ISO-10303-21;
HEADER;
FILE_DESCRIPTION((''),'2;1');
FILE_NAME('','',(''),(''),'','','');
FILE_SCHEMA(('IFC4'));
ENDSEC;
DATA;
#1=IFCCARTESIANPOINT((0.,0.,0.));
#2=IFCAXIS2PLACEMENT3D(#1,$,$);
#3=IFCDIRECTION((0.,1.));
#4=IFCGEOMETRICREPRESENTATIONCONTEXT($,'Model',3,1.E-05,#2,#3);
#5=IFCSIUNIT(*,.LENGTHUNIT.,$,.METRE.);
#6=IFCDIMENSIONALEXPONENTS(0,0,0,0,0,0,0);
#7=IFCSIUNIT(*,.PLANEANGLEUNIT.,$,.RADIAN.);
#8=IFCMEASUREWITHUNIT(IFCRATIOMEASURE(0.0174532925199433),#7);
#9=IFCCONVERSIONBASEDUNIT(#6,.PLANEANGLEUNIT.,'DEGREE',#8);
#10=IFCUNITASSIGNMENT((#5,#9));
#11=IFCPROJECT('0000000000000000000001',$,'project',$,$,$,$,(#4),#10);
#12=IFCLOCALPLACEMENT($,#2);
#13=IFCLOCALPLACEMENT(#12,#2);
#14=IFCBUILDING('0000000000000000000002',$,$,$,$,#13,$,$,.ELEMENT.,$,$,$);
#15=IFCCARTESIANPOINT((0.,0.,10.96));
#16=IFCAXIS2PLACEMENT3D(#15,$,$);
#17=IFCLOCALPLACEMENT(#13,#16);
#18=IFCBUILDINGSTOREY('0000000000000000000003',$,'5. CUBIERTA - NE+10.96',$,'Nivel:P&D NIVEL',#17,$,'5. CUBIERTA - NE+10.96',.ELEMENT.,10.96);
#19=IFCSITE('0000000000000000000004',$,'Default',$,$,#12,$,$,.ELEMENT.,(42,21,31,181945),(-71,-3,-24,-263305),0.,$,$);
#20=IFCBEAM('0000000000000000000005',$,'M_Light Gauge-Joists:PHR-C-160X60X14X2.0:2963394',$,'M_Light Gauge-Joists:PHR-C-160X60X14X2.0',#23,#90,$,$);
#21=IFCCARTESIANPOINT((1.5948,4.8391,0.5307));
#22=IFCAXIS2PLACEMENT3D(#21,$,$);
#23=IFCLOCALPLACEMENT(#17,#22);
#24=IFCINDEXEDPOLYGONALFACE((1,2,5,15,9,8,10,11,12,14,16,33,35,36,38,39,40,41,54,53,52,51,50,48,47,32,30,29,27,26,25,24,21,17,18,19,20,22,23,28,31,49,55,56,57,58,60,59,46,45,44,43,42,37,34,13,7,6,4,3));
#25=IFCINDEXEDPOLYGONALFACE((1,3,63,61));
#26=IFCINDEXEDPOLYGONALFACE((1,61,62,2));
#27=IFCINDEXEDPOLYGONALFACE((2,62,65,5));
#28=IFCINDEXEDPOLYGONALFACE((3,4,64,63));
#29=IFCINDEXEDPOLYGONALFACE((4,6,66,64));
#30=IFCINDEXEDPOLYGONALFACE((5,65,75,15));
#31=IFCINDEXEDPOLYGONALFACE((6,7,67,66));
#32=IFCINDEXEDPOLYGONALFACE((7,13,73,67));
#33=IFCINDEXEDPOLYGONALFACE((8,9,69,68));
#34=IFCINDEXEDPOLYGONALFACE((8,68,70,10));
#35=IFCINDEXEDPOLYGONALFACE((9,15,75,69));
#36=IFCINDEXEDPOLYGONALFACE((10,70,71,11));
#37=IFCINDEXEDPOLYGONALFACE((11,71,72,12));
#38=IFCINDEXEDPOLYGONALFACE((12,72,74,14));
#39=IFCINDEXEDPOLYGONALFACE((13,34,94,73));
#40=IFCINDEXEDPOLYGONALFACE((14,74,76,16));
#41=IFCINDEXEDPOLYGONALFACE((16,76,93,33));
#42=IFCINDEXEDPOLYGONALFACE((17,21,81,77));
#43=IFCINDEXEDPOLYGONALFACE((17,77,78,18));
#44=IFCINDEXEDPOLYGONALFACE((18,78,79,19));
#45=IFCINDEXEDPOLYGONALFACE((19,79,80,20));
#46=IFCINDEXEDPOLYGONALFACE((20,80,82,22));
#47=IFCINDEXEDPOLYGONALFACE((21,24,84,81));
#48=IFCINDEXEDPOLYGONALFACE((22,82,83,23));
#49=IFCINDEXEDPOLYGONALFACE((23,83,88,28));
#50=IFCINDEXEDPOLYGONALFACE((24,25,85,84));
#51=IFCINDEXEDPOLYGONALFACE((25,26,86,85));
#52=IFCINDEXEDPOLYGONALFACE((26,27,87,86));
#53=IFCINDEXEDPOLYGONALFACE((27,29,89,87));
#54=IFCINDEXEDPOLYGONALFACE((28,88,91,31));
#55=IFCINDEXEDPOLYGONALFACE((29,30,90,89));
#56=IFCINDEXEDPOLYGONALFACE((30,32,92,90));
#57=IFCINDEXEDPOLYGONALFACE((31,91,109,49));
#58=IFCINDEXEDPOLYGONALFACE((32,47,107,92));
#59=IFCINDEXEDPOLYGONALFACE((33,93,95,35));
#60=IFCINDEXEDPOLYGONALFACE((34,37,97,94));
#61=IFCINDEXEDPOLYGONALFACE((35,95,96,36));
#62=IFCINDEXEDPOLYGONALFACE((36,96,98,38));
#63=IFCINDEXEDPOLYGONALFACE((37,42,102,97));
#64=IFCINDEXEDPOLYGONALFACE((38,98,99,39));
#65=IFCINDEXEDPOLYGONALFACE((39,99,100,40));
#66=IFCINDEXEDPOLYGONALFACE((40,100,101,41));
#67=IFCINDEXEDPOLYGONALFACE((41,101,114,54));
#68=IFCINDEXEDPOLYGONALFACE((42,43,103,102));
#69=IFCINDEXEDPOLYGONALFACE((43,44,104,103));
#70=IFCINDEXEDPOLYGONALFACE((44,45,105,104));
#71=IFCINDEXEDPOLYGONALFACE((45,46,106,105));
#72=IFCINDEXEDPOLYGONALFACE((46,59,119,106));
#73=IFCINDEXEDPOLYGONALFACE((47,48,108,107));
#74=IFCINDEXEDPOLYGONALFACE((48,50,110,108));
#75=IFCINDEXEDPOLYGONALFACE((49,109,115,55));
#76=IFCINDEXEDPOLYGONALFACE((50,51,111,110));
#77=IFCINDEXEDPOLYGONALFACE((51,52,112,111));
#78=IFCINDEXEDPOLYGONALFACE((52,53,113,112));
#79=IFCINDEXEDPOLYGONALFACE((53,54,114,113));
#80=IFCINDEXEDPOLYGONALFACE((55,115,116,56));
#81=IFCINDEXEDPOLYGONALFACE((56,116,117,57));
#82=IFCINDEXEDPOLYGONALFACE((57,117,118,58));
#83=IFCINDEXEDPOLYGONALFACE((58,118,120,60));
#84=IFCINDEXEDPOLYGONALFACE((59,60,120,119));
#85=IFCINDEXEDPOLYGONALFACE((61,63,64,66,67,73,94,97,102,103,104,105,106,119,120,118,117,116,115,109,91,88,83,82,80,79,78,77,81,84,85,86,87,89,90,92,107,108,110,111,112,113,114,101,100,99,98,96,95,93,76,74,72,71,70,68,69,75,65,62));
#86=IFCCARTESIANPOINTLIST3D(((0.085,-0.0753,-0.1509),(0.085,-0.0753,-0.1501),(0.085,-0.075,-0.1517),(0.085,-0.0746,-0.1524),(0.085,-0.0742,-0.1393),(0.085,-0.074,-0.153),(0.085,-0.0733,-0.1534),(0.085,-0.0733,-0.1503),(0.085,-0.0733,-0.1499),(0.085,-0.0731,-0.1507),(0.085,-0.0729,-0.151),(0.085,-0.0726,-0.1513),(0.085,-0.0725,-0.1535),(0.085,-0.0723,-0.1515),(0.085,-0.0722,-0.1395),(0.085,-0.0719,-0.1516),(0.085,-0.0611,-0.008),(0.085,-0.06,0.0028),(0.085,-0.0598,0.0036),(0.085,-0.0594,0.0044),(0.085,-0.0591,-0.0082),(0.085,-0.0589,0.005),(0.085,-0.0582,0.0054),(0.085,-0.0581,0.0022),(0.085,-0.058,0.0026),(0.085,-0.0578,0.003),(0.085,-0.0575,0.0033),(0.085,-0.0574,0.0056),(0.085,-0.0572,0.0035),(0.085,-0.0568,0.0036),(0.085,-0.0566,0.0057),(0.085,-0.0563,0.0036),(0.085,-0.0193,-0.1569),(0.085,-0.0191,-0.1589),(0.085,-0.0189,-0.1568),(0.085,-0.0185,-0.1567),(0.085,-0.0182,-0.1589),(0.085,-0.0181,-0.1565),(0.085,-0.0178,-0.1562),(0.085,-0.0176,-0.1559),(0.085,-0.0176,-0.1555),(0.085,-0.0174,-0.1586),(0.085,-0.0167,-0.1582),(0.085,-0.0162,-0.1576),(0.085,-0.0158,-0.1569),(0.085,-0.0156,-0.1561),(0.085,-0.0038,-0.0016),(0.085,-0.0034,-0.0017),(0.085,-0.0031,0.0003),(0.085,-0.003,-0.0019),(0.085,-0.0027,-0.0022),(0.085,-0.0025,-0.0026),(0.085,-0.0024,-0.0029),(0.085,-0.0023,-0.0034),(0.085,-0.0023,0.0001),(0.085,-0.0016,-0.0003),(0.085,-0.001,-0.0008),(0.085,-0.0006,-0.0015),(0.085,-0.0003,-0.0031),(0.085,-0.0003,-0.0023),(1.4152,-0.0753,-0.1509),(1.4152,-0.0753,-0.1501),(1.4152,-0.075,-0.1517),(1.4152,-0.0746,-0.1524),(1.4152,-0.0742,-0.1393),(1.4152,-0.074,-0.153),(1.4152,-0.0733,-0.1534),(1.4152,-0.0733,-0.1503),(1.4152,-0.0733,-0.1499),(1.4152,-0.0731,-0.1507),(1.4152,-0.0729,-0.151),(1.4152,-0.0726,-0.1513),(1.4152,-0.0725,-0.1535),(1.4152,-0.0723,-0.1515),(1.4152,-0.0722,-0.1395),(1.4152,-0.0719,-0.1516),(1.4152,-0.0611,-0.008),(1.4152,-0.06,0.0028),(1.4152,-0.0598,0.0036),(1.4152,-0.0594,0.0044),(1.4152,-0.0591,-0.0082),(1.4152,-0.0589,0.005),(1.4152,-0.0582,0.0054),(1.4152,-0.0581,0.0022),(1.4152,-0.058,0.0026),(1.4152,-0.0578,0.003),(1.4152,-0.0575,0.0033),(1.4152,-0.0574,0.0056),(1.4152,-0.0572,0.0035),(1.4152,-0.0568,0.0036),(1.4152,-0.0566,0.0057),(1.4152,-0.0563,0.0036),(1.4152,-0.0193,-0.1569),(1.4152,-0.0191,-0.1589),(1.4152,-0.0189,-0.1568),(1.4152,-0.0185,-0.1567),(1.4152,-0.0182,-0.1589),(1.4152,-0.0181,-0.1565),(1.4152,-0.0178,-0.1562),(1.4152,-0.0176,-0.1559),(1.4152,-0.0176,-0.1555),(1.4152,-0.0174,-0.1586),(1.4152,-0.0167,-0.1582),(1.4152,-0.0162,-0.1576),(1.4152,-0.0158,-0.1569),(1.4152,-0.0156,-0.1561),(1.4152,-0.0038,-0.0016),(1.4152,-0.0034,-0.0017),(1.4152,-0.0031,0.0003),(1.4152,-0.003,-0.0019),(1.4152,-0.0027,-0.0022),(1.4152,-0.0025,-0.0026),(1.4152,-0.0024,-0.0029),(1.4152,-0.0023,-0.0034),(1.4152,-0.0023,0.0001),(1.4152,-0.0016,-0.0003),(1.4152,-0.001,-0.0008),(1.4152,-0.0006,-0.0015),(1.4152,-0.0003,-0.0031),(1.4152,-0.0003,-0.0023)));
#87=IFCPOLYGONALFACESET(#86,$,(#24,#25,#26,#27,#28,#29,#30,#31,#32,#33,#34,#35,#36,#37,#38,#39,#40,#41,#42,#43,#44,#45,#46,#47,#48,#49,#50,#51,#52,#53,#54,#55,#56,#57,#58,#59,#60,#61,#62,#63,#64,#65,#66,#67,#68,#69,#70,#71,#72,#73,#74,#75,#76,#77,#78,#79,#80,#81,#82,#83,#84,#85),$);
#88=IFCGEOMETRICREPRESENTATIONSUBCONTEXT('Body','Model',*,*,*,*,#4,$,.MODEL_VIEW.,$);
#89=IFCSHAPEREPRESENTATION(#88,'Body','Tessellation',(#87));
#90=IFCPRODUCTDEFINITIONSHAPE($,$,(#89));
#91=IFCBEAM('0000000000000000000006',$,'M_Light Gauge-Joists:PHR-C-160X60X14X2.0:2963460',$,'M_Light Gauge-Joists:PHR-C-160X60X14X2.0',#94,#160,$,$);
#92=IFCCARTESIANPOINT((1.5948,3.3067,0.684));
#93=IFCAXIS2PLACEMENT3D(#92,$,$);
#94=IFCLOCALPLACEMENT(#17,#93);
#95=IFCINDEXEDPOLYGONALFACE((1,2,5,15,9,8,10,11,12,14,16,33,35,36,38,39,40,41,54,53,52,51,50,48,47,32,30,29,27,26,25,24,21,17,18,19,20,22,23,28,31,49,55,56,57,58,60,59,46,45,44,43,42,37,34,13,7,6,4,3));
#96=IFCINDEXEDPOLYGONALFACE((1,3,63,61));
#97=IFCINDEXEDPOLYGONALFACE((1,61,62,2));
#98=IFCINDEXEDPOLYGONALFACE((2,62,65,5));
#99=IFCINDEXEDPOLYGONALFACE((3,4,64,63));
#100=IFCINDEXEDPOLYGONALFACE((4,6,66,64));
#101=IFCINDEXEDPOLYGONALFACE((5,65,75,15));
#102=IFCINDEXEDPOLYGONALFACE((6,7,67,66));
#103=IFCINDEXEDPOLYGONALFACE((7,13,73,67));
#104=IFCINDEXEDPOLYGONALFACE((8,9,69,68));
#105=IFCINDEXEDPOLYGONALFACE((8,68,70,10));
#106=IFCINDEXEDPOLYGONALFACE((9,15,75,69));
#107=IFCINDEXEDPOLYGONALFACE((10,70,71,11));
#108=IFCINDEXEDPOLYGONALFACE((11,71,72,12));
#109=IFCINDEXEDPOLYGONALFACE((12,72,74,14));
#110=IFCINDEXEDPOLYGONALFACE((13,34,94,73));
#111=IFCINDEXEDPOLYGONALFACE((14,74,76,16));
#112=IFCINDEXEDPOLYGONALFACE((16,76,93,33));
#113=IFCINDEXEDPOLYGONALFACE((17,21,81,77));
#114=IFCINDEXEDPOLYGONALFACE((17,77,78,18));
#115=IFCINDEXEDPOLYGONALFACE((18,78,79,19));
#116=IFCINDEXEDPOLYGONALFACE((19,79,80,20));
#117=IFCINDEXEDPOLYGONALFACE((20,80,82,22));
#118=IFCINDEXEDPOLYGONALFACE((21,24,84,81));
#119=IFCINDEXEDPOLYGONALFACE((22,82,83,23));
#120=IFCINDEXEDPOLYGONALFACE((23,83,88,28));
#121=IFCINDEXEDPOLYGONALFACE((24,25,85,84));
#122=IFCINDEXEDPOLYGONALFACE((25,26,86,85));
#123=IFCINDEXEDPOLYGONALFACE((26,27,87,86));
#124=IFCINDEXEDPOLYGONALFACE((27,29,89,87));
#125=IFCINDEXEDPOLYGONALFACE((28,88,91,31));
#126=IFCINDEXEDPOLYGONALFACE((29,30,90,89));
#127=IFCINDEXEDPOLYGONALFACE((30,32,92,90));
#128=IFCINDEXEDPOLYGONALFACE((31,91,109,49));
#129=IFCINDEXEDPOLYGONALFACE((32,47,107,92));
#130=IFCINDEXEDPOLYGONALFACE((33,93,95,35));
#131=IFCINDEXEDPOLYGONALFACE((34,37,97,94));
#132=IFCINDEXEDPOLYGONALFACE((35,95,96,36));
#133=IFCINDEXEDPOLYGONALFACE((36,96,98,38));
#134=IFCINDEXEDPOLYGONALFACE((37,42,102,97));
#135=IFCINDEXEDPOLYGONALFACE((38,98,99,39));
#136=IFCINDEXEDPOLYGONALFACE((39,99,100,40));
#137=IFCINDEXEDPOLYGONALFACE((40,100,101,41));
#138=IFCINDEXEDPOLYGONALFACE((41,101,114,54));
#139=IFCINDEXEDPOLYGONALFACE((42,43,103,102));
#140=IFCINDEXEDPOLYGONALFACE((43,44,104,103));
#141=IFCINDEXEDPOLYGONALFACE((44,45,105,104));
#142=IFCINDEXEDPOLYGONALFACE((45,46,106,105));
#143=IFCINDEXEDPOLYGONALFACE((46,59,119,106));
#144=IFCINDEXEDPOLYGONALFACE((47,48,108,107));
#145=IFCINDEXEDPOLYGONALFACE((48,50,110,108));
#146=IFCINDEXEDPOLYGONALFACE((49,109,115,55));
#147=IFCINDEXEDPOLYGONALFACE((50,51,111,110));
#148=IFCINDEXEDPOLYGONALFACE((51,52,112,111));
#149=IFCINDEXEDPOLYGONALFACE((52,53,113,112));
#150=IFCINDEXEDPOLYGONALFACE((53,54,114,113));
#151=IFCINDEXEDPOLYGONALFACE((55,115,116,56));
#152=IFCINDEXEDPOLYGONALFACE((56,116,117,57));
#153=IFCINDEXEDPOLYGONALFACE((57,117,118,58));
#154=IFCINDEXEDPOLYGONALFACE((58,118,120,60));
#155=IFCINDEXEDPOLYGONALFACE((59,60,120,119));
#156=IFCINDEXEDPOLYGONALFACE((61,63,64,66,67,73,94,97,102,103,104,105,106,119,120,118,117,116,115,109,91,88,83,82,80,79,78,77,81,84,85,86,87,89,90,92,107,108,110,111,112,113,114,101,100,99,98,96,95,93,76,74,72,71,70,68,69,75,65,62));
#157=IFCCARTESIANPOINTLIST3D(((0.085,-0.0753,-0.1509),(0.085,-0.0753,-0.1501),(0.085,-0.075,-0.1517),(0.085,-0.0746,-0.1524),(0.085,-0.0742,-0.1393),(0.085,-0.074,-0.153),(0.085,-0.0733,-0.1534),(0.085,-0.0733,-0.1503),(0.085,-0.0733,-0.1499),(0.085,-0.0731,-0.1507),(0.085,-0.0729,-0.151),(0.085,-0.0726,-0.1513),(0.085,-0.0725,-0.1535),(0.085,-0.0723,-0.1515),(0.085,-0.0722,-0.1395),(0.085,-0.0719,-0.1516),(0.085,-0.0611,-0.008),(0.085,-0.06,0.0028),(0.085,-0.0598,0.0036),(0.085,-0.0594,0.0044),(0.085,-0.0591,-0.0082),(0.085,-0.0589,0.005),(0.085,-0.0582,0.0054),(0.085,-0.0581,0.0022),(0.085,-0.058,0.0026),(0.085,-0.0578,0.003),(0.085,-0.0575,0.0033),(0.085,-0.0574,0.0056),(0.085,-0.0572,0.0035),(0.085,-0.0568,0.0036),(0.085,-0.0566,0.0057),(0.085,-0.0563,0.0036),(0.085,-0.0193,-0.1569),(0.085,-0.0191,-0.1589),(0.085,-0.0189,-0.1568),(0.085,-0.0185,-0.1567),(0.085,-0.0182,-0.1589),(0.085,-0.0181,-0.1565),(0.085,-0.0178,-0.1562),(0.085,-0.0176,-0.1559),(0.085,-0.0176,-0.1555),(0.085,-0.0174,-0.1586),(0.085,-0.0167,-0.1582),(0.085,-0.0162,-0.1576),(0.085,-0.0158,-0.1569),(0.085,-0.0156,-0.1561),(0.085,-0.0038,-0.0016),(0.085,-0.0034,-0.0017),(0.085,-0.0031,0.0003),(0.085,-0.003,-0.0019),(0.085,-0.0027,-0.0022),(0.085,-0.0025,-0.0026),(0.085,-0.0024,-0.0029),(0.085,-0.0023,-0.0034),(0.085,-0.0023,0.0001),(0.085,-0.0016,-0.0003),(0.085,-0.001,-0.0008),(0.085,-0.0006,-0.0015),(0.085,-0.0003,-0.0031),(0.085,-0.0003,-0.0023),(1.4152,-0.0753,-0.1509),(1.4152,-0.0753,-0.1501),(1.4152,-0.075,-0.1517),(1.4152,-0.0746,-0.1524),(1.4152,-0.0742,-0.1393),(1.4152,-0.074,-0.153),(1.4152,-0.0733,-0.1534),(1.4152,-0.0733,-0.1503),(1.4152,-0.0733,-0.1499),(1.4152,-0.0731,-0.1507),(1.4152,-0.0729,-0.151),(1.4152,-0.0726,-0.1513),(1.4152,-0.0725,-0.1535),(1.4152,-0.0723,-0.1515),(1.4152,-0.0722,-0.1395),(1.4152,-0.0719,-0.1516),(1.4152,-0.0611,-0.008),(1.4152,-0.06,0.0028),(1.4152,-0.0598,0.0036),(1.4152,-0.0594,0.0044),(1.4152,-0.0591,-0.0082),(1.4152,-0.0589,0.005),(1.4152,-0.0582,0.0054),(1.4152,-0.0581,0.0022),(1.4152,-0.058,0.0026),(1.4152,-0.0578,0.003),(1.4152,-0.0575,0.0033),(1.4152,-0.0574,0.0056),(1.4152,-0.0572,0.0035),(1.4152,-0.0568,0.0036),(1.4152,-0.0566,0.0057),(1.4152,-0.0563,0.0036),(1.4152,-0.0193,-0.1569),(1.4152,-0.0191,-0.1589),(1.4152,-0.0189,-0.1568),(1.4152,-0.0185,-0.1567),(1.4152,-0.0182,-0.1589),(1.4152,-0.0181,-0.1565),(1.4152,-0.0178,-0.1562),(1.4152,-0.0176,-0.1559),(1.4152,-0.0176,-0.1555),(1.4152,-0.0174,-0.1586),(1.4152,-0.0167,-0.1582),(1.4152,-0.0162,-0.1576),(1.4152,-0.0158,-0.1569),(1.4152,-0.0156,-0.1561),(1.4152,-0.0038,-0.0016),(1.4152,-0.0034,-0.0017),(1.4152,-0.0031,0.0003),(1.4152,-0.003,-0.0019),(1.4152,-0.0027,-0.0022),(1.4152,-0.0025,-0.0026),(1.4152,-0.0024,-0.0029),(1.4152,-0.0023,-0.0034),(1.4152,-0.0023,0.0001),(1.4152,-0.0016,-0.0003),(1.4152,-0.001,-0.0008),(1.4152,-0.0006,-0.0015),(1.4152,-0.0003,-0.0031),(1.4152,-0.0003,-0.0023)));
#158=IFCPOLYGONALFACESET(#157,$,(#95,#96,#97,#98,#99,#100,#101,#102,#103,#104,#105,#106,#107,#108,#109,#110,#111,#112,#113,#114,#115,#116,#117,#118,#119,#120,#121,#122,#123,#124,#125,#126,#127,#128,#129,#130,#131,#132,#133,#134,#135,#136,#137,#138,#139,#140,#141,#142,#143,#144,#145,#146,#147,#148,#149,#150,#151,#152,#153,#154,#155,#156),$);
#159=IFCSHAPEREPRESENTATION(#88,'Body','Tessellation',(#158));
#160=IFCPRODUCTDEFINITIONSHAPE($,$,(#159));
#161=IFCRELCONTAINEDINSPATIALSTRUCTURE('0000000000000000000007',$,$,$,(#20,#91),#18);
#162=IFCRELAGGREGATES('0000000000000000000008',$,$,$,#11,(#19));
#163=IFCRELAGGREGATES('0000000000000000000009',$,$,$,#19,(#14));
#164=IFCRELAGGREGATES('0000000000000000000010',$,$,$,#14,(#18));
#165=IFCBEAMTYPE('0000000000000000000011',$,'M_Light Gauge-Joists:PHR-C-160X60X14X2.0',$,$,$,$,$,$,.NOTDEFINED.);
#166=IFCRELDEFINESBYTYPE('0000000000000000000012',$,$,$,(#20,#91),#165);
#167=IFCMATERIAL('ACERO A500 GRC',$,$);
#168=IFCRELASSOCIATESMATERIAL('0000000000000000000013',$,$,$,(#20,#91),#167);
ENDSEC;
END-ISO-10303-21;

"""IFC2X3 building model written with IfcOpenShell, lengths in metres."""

from ifc_helpers import new_model, entity, si_unit, converted_unit, direction, frame, frame_2d, origin, place, context, subcontext, project, spatial, polyline, circle_curve, parameter, trimmed, segment, composite_curve, outline, extrude, material, type_object, element, save


model = new_model("IFC2X3")

# Units and contexts
model_context = context("Model", 3, precision=1e-05, world=origin(), true_north=direction((0.0, 1.0)))
body_context = subcontext(model_context, "Body", "Model", "MODEL_VIEW")
ifc_project = project(units=[si_unit("LENGTHUNIT", "METRE"), converted_unit("PLANEANGLEUNIT", "DEGREE", entity("IfcRatioMeasure", 0.0174532925199433), si_unit("PLANEANGLEUNIT", "RADIAN"), dimensions=[0, 0, 0, 0, 0, 0, 0])], contexts=[model_context])

# Site, building, storey
site_placement = place(None, origin())
site = spatial("IfcSite", under=ifc_project, at=site_placement, Name="Default", CompositionType="ELEMENT", RefLatitude=(42, 21, 31, 181945), RefLongitude=(-71, -3, -24, -263305), RefElevation=0.0)
building_placement = place(site_placement, origin())
building = spatial("IfcBuilding", under=site, at=building_placement, CompositionType="ELEMENT")
storey_placement = place(building_placement, frame((0.0, 0.0, 10.96)))
storey = spatial("IfcBuildingStorey", under=building, at=storey_placement, Name="5. CUBIERTA - NE+10.96", ObjectType="Nivel:P&D NIVEL", LongName="5. CUBIERTA - NE+10.96", CompositionType="ELEMENT", Elevation=10.96)

# Beams
ifc_material_1 = material(Name="ACERO A500 GRC")
beam_type_1 = type_object("IfcBeamType", Name="M_Light Gauge-Joists:PHR-C-160X60X14X2.0", PredefinedType="NOTDEFINED")
beam_1_placement = place(storey_placement, frame((1.5948, 4.8391, 0.5307)))
element("IfcBeam", 1, at=beam_1_placement, inside=storey, type_object=beam_type_1, material=ifc_material_1, Name="M_Light Gauge-Joists:PHR-C-160X60X14X2.0:2963394", ObjectType="M_Light Gauge-Joists:PHR-C-160X60X14X2.0", context=body_context, shape_type="SweptSolid", body=[
    extrude(outline(composite_curve([segment(polyline([(-0.0768, -0.0358), (0.0768, -0.0358)]), True, "CONTINUOUS"), segment(trimmed(circle_curve(frame_2d((0.0768, -0.0326), x_axis=(0.0, -1.0)), 0.0032), [parameter(0.0)], [parameter(90.0)], True, "PARAMETER"), True, "CONTINUOUS"), segment(polyline([(0.08, -0.0326), (0.08, 0.021)]), True, "CONTINUOUS"), segment(trimmed(circle_curve(frame_2d((0.0768, 0.021), x_axis=(1.0, 0.0)), 0.0032), [parameter(0.0)], [parameter(90.0)], True, "PARAMETER"), True, "CONTINUOUS"), segment(polyline([(0.0768, 0.0242), (0.066, 0.0242)]), True, "CONTINUOUS"), segment(polyline([(0.066, 0.0242), (0.066, 0.0222)]), True, "CONTINUOUS"), segment(polyline([(0.066, 0.0222), (0.0764, 0.0222)]), True, "CONTINUOUS"), segment(trimmed(circle_curve(frame_2d((0.0764, 0.0206), x_axis=(0.0, 1.0)), 0.0016), [parameter(270.0)], [parameter(0.0)], True, "PARAMETER"), False, "CONTINUOUS"), segment(polyline([(0.078, 0.0206), (0.078, -0.0322)]), True, "CONTINUOUS"), segment(trimmed(circle_curve(frame_2d((0.0764, -0.0322), x_axis=(1.0, 0.0)), 0.0016), [parameter(270.0)], [parameter(0.0)], True, "PARAMETER"), False, "CONTINUOUS"), segment(polyline([(0.0764, -0.0338), (-0.0764, -0.0338)]), True, "CONTINUOUS"), segment(trimmed(circle_curve(frame_2d((-0.0764, -0.0322), x_axis=(0.0, -1.0)), 0.0016), [parameter(270.0)], [parameter(0.0)], True, "PARAMETER"), False, "CONTINUOUS"), segment(polyline([(-0.078, -0.0322), (-0.078, 0.0206)]), True, "CONTINUOUS"), segment(trimmed(circle_curve(frame_2d((-0.0764, 0.0206), x_axis=(-1.0, 0.0)), 0.0016), [parameter(270.0)], [parameter(0.0)], True, "PARAMETER"), False, "CONTINUOUS"), segment(polyline([(-0.0764, 0.0222), (-0.066, 0.0222)]), True, "CONTINUOUS"), segment(polyline([(-0.066, 0.0222), (-0.066, 0.0242)]), True, "CONTINUOUS"), segment(polyline([(-0.066, 0.0242), (-0.0768, 0.0242)]), True, "CONTINUOUS"), segment(trimmed(circle_curve(frame_2d((-0.0768, 0.021), x_axis=(0.0, 1.0)), 0.0032), [parameter(0.0)], [parameter(90.0)], True, "PARAMETER"), True, "CONTINUOUS"), segment(polyline([(-0.08, 0.021), (-0.08, -0.0326)]), True, "CONTINUOUS"), segment(trimmed(circle_curve(frame_2d((-0.0768, -0.0326), x_axis=(-1.0, 0.0)), 0.0032), [parameter(0.0)], [parameter(90.0)], True, "PARAMETER"), True, "CONTINUOUS")], self_intersect=False)), frame((0.085, -0.0436, -0.076), z_axis=(1.0, 0.0, 0.0), x_axis=(0.0, 0.099504, 0.995037)), (0.0, 0.0, 1.0), 1.3302),
])
beam_2_placement = place(storey_placement, frame((1.5948, 3.3067, 0.684)))
element("IfcBeam", 2, at=beam_2_placement, inside=storey, type_object=beam_type_1, material=ifc_material_1, Name="M_Light Gauge-Joists:PHR-C-160X60X14X2.0:2963460", ObjectType="M_Light Gauge-Joists:PHR-C-160X60X14X2.0", context=body_context, shape_type="SweptSolid", body=[
    extrude(outline(composite_curve([segment(polyline([(-0.0768, -0.0358), (0.0768, -0.0358)]), True, "CONTINUOUS"), segment(trimmed(circle_curve(frame_2d((0.0768, -0.0326), x_axis=(0.0, -1.0)), 0.0032), [parameter(0.0)], [parameter(90.0)], True, "PARAMETER"), True, "CONTINUOUS"), segment(polyline([(0.08, -0.0326), (0.08, 0.021)]), True, "CONTINUOUS"), segment(trimmed(circle_curve(frame_2d((0.0768, 0.021), x_axis=(1.0, 0.0)), 0.0032), [parameter(0.0)], [parameter(90.0)], True, "PARAMETER"), True, "CONTINUOUS"), segment(polyline([(0.0768, 0.0242), (0.066, 0.0242)]), True, "CONTINUOUS"), segment(polyline([(0.066, 0.0242), (0.066, 0.0222)]), True, "CONTINUOUS"), segment(polyline([(0.066, 0.0222), (0.0764, 0.0222)]), True, "CONTINUOUS"), segment(trimmed(circle_curve(frame_2d((0.0764, 0.0206), x_axis=(0.0, 1.0)), 0.0016), [parameter(270.0)], [parameter(0.0)], True, "PARAMETER"), False, "CONTINUOUS"), segment(polyline([(0.078, 0.0206), (0.078, -0.0322)]), True, "CONTINUOUS"), segment(trimmed(circle_curve(frame_2d((0.0764, -0.0322), x_axis=(1.0, 0.0)), 0.0016), [parameter(270.0)], [parameter(0.0)], True, "PARAMETER"), False, "CONTINUOUS"), segment(polyline([(0.0764, -0.0338), (-0.0764, -0.0338)]), True, "CONTINUOUS"), segment(trimmed(circle_curve(frame_2d((-0.0764, -0.0322), x_axis=(0.0, -1.0)), 0.0016), [parameter(270.0)], [parameter(0.0)], True, "PARAMETER"), False, "CONTINUOUS"), segment(polyline([(-0.078, -0.0322), (-0.078, 0.0206)]), True, "CONTINUOUS"), segment(trimmed(circle_curve(frame_2d((-0.0764, 0.0206), x_axis=(-1.0, 0.0)), 0.0016), [parameter(270.0)], [parameter(0.0)], True, "PARAMETER"), False, "CONTINUOUS"), segment(polyline([(-0.0764, 0.0222), (-0.066, 0.0222)]), True, "CONTINUOUS"), segment(polyline([(-0.066, 0.0222), (-0.066, 0.0242)]), True, "CONTINUOUS"), segment(polyline([(-0.066, 0.0242), (-0.0768, 0.0242)]), True, "CONTINUOUS"), segment(trimmed(circle_curve(frame_2d((-0.0768, 0.021), x_axis=(0.0, 1.0)), 0.0032), [parameter(0.0)], [parameter(90.0)], True, "PARAMETER"), True, "CONTINUOUS"), segment(polyline([(-0.08, 0.021), (-0.08, -0.0326)]), True, "CONTINUOUS"), segment(trimmed(circle_curve(frame_2d((-0.0768, -0.0326), x_axis=(-1.0, 0.0)), 0.0032), [parameter(0.0)], [parameter(90.0)], True, "PARAMETER"), True, "CONTINUOUS")], self_intersect=False)), frame((0.085, -0.0436, -0.076), z_axis=(1.0, 0.0, 0.0), x_axis=(0.0, 0.099504, 0.995037)), (0.0, 0.0, 1.0), 1.3302),
])

save(model, "model.ifc")
